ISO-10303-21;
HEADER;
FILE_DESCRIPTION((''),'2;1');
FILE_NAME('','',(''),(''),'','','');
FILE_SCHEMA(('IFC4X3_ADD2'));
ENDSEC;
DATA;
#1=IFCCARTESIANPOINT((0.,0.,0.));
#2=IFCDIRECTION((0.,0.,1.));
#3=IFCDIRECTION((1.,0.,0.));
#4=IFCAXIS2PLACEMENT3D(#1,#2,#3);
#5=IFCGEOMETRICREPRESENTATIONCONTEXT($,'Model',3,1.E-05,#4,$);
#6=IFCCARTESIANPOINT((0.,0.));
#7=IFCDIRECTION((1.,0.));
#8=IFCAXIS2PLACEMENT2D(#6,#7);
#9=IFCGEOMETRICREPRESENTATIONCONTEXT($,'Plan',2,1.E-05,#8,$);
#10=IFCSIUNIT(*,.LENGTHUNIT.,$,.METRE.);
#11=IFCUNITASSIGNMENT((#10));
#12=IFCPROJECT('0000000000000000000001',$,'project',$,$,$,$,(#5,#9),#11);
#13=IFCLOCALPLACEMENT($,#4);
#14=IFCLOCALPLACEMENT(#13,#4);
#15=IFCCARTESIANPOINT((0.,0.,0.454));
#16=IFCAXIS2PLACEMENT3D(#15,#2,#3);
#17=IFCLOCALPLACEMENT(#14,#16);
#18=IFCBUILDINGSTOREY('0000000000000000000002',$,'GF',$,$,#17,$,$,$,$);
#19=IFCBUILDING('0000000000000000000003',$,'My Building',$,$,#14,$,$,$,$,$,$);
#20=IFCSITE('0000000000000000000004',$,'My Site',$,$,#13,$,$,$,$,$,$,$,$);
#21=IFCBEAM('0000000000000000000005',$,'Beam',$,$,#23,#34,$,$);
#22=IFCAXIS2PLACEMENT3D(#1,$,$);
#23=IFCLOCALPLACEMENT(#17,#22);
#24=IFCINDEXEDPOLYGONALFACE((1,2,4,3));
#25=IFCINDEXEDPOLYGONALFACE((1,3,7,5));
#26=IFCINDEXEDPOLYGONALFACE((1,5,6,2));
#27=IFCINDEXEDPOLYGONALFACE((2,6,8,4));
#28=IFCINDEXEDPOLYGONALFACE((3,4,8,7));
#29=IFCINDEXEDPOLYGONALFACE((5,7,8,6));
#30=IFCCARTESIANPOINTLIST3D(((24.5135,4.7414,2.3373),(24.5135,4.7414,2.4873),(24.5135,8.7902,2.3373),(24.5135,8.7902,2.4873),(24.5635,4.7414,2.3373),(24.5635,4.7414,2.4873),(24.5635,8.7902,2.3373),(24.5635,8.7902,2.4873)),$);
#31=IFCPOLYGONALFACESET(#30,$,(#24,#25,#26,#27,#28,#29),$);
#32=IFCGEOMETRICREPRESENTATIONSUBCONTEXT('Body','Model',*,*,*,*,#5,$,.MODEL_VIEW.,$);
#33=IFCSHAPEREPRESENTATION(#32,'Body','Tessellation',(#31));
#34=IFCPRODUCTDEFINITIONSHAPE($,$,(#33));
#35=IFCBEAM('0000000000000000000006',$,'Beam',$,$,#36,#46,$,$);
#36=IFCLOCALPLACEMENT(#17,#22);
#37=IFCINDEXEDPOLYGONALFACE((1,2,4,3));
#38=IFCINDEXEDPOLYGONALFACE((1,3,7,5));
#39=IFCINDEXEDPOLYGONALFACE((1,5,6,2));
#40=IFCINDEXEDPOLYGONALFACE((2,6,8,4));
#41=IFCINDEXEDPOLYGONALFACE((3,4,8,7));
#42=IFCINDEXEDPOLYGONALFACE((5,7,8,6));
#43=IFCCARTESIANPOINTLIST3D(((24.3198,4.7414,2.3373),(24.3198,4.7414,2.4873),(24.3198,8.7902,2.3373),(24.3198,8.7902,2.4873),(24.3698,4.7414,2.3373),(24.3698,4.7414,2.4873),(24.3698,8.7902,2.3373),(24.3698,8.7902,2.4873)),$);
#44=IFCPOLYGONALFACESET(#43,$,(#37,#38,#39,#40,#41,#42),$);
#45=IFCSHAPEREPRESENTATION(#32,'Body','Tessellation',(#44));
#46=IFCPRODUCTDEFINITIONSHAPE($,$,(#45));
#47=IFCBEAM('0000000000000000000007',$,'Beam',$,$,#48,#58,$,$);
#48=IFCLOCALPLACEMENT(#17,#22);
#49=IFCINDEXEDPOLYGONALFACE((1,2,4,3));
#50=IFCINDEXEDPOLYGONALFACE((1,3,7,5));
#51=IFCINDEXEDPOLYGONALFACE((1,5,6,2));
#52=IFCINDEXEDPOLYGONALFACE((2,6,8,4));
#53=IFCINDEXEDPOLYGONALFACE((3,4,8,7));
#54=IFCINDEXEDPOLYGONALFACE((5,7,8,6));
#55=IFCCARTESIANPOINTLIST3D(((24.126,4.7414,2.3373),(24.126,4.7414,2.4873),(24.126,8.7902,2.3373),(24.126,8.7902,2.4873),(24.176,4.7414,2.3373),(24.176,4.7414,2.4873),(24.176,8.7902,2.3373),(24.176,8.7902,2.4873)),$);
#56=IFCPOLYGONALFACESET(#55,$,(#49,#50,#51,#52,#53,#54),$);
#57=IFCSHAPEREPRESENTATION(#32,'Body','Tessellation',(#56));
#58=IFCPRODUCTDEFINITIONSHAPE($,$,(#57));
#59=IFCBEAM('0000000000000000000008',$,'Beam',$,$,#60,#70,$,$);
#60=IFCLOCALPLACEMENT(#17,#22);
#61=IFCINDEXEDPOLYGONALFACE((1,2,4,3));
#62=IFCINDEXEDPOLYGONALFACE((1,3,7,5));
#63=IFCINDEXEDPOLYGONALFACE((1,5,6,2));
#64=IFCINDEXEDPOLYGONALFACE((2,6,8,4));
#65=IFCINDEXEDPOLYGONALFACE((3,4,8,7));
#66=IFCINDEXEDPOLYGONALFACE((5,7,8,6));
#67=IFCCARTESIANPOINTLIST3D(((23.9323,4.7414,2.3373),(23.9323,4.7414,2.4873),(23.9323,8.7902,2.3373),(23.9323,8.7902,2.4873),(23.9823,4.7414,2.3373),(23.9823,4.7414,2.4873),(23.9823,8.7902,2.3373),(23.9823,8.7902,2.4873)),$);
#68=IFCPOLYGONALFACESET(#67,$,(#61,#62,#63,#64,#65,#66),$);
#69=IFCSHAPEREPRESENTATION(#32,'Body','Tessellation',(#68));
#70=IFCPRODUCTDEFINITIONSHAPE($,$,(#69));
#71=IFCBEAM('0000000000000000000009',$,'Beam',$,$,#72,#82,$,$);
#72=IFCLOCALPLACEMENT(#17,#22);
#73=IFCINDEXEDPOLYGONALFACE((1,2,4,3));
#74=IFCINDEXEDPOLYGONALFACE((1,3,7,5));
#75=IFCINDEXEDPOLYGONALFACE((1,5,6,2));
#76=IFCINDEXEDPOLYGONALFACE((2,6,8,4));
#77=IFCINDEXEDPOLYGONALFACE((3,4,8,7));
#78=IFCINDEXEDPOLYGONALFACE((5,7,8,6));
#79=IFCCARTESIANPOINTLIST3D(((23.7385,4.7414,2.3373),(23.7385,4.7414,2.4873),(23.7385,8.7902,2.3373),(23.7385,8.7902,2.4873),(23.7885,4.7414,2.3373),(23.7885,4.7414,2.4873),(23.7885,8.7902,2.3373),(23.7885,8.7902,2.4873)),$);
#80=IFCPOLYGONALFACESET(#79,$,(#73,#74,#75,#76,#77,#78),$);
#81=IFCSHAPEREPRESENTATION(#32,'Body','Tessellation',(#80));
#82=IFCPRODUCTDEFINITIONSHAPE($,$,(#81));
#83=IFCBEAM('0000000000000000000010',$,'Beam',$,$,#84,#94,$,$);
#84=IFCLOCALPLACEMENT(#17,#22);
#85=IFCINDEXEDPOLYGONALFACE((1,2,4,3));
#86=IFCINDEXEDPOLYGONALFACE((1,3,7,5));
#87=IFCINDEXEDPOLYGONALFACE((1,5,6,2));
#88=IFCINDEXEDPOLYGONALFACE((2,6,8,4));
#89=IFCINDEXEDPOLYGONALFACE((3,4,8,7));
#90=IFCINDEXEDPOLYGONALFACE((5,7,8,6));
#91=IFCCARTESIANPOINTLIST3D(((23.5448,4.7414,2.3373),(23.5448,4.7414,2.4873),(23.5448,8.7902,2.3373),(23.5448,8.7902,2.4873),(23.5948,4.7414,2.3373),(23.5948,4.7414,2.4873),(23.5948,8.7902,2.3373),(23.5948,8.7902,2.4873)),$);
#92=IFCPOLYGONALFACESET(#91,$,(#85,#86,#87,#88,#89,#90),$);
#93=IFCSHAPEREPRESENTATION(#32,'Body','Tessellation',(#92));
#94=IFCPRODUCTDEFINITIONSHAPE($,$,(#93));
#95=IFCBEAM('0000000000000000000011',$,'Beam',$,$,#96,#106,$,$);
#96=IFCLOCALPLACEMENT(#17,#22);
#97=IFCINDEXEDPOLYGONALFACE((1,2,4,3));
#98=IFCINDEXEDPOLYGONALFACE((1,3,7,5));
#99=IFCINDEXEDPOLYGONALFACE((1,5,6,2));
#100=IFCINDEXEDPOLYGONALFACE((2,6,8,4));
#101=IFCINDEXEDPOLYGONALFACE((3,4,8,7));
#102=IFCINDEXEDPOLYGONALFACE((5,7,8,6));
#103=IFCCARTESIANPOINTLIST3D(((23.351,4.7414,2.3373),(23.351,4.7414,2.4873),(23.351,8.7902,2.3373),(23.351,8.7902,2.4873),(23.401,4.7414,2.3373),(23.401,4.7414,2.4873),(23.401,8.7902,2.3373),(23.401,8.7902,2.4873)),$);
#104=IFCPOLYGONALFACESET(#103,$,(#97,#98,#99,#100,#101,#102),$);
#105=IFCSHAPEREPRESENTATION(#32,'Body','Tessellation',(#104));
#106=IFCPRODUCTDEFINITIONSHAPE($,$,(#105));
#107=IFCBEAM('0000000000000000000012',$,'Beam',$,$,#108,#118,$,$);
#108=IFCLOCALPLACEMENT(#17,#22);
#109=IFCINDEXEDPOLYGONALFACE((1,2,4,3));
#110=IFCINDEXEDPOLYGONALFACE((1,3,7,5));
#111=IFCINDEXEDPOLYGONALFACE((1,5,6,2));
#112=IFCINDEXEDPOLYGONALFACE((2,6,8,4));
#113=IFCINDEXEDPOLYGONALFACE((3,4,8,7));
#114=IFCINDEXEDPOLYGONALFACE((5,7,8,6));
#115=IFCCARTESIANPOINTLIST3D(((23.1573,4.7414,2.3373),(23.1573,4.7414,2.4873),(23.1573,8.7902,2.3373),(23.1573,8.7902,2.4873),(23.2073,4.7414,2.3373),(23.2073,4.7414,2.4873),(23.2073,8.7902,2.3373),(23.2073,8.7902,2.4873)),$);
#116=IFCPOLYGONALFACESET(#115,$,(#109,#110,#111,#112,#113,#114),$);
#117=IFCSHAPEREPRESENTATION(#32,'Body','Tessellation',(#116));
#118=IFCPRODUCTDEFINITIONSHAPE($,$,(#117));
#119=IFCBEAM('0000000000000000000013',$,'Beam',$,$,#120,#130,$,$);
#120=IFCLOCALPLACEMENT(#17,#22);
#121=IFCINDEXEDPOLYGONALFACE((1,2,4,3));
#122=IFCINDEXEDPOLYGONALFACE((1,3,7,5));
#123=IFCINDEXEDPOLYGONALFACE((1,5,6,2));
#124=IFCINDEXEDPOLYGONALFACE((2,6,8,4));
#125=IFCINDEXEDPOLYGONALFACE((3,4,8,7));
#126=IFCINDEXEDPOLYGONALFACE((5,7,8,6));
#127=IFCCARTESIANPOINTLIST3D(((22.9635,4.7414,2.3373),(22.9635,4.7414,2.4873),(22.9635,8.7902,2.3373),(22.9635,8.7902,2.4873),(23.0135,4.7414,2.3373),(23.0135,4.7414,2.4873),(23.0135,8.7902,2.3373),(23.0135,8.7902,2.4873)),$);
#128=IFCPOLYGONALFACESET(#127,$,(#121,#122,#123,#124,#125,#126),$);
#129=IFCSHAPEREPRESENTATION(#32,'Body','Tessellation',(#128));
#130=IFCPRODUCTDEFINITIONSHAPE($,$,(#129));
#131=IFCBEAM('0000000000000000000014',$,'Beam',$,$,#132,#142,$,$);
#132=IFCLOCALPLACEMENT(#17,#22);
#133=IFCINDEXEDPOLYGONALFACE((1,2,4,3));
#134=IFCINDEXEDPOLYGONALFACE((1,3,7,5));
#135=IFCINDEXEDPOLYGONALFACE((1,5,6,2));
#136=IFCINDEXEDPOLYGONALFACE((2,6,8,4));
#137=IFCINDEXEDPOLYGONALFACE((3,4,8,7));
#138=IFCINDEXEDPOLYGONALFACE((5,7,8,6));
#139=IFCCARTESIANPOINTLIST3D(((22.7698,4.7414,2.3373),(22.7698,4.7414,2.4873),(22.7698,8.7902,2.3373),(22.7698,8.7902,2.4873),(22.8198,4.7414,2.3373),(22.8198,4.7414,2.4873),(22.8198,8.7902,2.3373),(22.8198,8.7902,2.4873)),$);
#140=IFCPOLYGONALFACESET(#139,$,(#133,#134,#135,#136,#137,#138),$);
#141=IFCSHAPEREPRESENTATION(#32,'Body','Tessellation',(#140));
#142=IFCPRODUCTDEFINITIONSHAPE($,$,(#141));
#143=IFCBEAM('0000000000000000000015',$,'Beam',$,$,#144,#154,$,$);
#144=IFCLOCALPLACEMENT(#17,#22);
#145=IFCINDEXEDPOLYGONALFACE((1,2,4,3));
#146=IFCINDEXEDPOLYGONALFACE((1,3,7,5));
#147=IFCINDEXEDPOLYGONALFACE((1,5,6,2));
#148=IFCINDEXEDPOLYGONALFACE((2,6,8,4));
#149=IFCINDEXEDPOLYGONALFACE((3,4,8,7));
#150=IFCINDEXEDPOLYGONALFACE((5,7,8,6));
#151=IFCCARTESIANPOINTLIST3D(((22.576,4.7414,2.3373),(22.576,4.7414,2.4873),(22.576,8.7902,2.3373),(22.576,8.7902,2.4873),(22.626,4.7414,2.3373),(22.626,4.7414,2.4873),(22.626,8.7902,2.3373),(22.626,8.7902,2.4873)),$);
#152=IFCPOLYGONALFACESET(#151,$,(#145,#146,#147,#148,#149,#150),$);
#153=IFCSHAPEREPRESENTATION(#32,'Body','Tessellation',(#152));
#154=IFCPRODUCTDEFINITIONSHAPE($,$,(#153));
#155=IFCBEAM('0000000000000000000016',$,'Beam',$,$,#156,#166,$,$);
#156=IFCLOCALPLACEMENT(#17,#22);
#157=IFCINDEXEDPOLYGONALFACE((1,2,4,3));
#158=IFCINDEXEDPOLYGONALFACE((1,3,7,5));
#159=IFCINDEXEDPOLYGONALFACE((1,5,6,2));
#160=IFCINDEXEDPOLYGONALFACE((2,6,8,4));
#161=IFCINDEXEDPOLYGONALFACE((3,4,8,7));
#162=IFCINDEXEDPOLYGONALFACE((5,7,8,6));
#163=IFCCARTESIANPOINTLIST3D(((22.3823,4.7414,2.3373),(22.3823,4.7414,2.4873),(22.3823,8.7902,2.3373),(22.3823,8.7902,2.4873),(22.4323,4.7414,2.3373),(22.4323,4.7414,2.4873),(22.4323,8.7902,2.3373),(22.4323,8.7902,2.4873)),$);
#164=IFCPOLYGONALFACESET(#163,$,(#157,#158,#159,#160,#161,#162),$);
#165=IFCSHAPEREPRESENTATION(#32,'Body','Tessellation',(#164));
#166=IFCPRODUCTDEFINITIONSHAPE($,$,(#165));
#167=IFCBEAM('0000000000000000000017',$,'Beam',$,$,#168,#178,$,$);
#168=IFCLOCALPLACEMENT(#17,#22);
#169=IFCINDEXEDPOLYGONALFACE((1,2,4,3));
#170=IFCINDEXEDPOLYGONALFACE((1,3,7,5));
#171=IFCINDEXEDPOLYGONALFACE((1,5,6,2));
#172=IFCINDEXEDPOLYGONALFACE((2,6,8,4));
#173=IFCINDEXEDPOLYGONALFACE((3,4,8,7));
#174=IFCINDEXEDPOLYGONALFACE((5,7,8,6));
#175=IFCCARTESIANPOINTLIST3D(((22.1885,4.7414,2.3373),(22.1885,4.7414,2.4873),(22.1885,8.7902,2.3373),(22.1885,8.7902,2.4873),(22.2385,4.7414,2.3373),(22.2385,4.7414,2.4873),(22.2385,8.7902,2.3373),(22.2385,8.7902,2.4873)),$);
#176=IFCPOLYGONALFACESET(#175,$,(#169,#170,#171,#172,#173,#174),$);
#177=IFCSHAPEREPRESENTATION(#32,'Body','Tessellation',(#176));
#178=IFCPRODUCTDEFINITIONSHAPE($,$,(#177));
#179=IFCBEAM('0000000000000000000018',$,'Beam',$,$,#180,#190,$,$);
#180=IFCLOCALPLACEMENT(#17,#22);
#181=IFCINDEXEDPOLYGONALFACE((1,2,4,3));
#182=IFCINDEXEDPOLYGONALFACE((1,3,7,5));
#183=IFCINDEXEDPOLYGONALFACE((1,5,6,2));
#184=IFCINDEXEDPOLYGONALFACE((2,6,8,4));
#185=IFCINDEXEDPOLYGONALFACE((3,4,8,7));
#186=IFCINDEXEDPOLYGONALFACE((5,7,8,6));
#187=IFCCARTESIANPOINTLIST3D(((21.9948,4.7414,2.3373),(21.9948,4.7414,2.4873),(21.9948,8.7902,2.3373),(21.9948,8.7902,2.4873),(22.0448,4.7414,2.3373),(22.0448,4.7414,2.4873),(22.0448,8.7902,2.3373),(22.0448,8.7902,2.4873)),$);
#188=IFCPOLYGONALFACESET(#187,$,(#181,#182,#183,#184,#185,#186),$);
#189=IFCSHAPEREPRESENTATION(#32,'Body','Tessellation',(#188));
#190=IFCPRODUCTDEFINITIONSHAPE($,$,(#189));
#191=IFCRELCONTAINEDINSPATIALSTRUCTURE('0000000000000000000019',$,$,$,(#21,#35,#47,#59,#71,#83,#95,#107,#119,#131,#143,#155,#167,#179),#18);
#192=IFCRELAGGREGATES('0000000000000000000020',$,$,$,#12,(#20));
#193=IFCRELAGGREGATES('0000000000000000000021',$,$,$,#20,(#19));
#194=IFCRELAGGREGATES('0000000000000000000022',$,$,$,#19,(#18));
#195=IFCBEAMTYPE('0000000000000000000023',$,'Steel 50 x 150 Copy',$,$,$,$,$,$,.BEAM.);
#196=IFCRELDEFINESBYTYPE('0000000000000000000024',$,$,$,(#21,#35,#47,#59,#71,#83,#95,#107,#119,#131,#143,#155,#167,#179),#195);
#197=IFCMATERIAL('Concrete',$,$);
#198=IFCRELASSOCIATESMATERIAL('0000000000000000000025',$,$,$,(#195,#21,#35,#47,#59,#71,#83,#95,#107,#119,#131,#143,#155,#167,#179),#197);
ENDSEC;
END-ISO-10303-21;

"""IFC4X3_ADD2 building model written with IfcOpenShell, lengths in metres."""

from ifc_helpers import new_model, si_unit, frame, origin_with_axes, origin_2d_with_axis, place, context, subcontext, project, spatial, rectangle, extrude, material, material_profile, profile_set, profile_usage, type_object, element, save


model = new_model("IFC4X3_ADD2")

# Units and contexts
model_context = context("Model", 3, precision=1e-05, world=origin_with_axes())
plan_context = context("Plan", 2, precision=1e-05, world=origin_2d_with_axis())
body_context_1 = subcontext(model_context, "Body", "Model", "MODEL_VIEW")
ifc_project = project(units=[si_unit("LENGTHUNIT", "METRE")], contexts=[model_context, plan_context])

# Site, building, storey
site_placement = place(None, origin_with_axes())
site = spatial("IfcSite", under=ifc_project, at=site_placement, Name="My Site")
building_placement = place(site_placement, origin_with_axes())
building = spatial("IfcBuilding", under=site, at=building_placement, Name="My Building")
storey_placement = place(building_placement, frame((0.0, 0.0, 0.454), z_axis=(0.0, 0.0, 1.0), x_axis=(1.0, 0.0, 0.0)))
storey = spatial("IfcBuildingStorey", under=building, at=storey_placement, Name="GF")

# Beams
ifc_material_1 = material(Name="Concrete")
ifc_material_profile_1 = material_profile(ifc_material_1, rectangle(XDim=0.05, YDim=0.15))
ifc_profile_set_1 = profile_set([ifc_material_profile_1])
beam_type_1 = type_object("IfcBeamType", Name="Steel 50 x 150 Copy", PredefinedType="BEAM", material=ifc_profile_set_1)
ifc_profile_usage_1 = profile_usage(ifc_profile_set_1)
beam_1_placement = place(storey_placement, frame((24.5385, 8.7902, 2.4123), z_axis=(0.0, -1.0, 0.0), x_axis=(1.0, 0.0, 0.0)))
element("IfcBeam", 1, at=beam_1_placement, inside=storey, type_object=beam_type_1, material=ifc_profile_usage_1, Name="Beam", context=body_context_1, shape_type="SweptSolid", body=[
    extrude(rectangle(XDim=0.05, YDim=0.15), origin_with_axes(), (0.0, 0.0, 1.0), 4.0488),
])
ifc_profile_usage_2 = profile_usage(ifc_profile_set_1)
beam_2_placement = place(storey_placement, frame((24.3448, 8.7902, 2.4123), z_axis=(0.0, -1.0, 0.0), x_axis=(1.0, 0.0, 0.0)))
element("IfcBeam", 2, at=beam_2_placement, inside=storey, type_object=beam_type_1, material=ifc_profile_usage_2, Name="Beam", context=body_context_1, shape_type="SweptSolid", body=[
    extrude(rectangle(XDim=0.05, YDim=0.15), origin_with_axes(), (0.0, 0.0, 1.0), 4.0488),
])
ifc_profile_usage_3 = profile_usage(ifc_profile_set_1)
beam_3_placement = place(storey_placement, frame((24.151, 8.7902, 2.4123), z_axis=(0.0, -1.0, 0.0), x_axis=(1.0, 0.0, 0.0)))
element("IfcBeam", 3, at=beam_3_placement, inside=storey, type_object=beam_type_1, material=ifc_profile_usage_3, Name="Beam", context=body_context_1, shape_type="SweptSolid", body=[
    extrude(rectangle(XDim=0.05, YDim=0.15), origin_with_axes(), (0.0, 0.0, 1.0), 4.0488),
])
ifc_profile_usage_4 = profile_usage(ifc_profile_set_1)
beam_4_placement = place(storey_placement, frame((23.9573, 8.7902, 2.4123), z_axis=(0.0, -1.0, 0.0), x_axis=(1.0, 0.0, 0.0)))
element("IfcBeam", 4, at=beam_4_placement, inside=storey, type_object=beam_type_1, material=ifc_profile_usage_4, Name="Beam", context=body_context_1, shape_type="SweptSolid", body=[
    extrude(rectangle(XDim=0.05, YDim=0.15), origin_with_axes(), (0.0, 0.0, 1.0), 4.0488),
])
ifc_profile_usage_5 = profile_usage(ifc_profile_set_1)
beam_5_placement = place(storey_placement, frame((23.7635, 8.7902, 2.4123), z_axis=(0.0, -1.0, 0.0), x_axis=(1.0, 0.0, 0.0)))
element("IfcBeam", 5, at=beam_5_placement, inside=storey, type_object=beam_type_1, material=ifc_profile_usage_5, Name="Beam", context=body_context_1, shape_type="SweptSolid", body=[
    extrude(rectangle(XDim=0.05, YDim=0.15), origin_with_axes(), (0.0, 0.0, 1.0), 4.0488),
])
ifc_profile_usage_6 = profile_usage(ifc_profile_set_1)
beam_6_placement = place(storey_placement, frame((23.5698, 8.7902, 2.4123), z_axis=(0.0, -1.0, 0.0), x_axis=(1.0, 0.0, 0.0)))
element("IfcBeam", 6, at=beam_6_placement, inside=storey, type_object=beam_type_1, material=ifc_profile_usage_6, Name="Beam", context=body_context_1, shape_type="SweptSolid", body=[
    extrude(rectangle(XDim=0.05, YDim=0.15), origin_with_axes(), (0.0, 0.0, 1.0), 4.0488),
])
ifc_profile_usage_7 = profile_usage(ifc_profile_set_1)
beam_7_placement = place(storey_placement, frame((23.376, 8.7902, 2.4123), z_axis=(0.0, -1.0, 0.0), x_axis=(1.0, 0.0, 0.0)))
element("IfcBeam", 7, at=beam_7_placement, inside=storey, type_object=beam_type_1, material=ifc_profile_usage_7, Name="Beam", context=body_context_1, shape_type="SweptSolid", body=[
    extrude(rectangle(XDim=0.05, YDim=0.15), origin_with_axes(), (0.0, 0.0, 1.0), 4.0488),
])
ifc_profile_usage_8 = profile_usage(ifc_profile_set_1)
beam_8_placement = place(storey_placement, frame((23.1823, 8.7902, 2.4123), z_axis=(0.0, -1.0, 0.0), x_axis=(1.0, 0.0, 0.0)))
element("IfcBeam", 8, at=beam_8_placement, inside=storey, type_object=beam_type_1, material=ifc_profile_usage_8, Name="Beam", context=body_context_1, shape_type="SweptSolid", body=[
    extrude(rectangle(XDim=0.05, YDim=0.15), origin_with_axes(), (0.0, 0.0, 1.0), 4.0488),
])
ifc_profile_usage_9 = profile_usage(ifc_profile_set_1)
beam_9_placement = place(storey_placement, frame((22.9885, 8.7902, 2.4123), z_axis=(0.0, -1.0, 0.0), x_axis=(1.0, 0.0, 0.0)))
element("IfcBeam", 9, at=beam_9_placement, inside=storey, type_object=beam_type_1, material=ifc_profile_usage_9, Name="Beam", context=body_context_1, shape_type="SweptSolid", body=[
    extrude(rectangle(XDim=0.05, YDim=0.15), origin_with_axes(), (0.0, 0.0, 1.0), 4.0488),
])
ifc_profile_usage_10 = profile_usage(ifc_profile_set_1)
beam_10_placement = place(storey_placement, frame((22.7948, 8.7902, 2.4123), z_axis=(0.0, -1.0, 0.0), x_axis=(1.0, 0.0, 0.0)))
element("IfcBeam", 10, at=beam_10_placement, inside=storey, type_object=beam_type_1, material=ifc_profile_usage_10, Name="Beam", context=body_context_1, shape_type="SweptSolid", body=[
    extrude(rectangle(XDim=0.05, YDim=0.15), origin_with_axes(), (0.0, 0.0, 1.0), 4.0488),
])
ifc_profile_usage_11 = profile_usage(ifc_profile_set_1)
beam_11_placement = place(storey_placement, frame((22.601, 8.7902, 2.4123), z_axis=(0.0, -1.0, 0.0), x_axis=(1.0, 0.0, 0.0)))
element("IfcBeam", 11, at=beam_11_placement, inside=storey, type_object=beam_type_1, material=ifc_profile_usage_11, Name="Beam", context=body_context_1, shape_type="SweptSolid", body=[
    extrude(rectangle(XDim=0.05, YDim=0.15), origin_with_axes(), (0.0, 0.0, 1.0), 4.0488),
])
ifc_profile_usage_12 = profile_usage(ifc_profile_set_1)
beam_12_placement = place(storey_placement, frame((22.4073, 8.7902, 2.4123), z_axis=(0.0, -1.0, 0.0), x_axis=(1.0, 0.0, 0.0)))
element("IfcBeam", 12, at=beam_12_placement, inside=storey, type_object=beam_type_1, material=ifc_profile_usage_12, Name="Beam", context=body_context_1, shape_type="SweptSolid", body=[
    extrude(rectangle(XDim=0.05, YDim=0.15), origin_with_axes(), (0.0, 0.0, 1.0), 4.0488),
])
ifc_profile_usage_13 = profile_usage(ifc_profile_set_1)
beam_13_placement = place(storey_placement, frame((22.2135, 8.7902, 2.4123), z_axis=(0.0, -1.0, 0.0), x_axis=(1.0, 0.0, 0.0)))
element("IfcBeam", 13, at=beam_13_placement, inside=storey, type_object=beam_type_1, material=ifc_profile_usage_13, Name="Beam", context=body_context_1, shape_type="SweptSolid", body=[
    extrude(rectangle(XDim=0.05, YDim=0.15), origin_with_axes(), (0.0, 0.0, 1.0), 4.0488),
])
ifc_profile_usage_14 = profile_usage(ifc_profile_set_1)
beam_14_placement = place(storey_placement, frame((22.0198, 8.7902, 2.4123), z_axis=(0.0, -1.0, 0.0), x_axis=(1.0, 0.0, 0.0)))
element("IfcBeam", 14, at=beam_14_placement, inside=storey, type_object=beam_type_1, material=ifc_profile_usage_14, Name="Beam", context=body_context_1, shape_type="SweptSolid", body=[
    extrude(rectangle(XDim=0.05, YDim=0.15), origin_with_axes(), (0.0, 0.0, 1.0), 4.0488),
])

save(model, "model.ifc")
